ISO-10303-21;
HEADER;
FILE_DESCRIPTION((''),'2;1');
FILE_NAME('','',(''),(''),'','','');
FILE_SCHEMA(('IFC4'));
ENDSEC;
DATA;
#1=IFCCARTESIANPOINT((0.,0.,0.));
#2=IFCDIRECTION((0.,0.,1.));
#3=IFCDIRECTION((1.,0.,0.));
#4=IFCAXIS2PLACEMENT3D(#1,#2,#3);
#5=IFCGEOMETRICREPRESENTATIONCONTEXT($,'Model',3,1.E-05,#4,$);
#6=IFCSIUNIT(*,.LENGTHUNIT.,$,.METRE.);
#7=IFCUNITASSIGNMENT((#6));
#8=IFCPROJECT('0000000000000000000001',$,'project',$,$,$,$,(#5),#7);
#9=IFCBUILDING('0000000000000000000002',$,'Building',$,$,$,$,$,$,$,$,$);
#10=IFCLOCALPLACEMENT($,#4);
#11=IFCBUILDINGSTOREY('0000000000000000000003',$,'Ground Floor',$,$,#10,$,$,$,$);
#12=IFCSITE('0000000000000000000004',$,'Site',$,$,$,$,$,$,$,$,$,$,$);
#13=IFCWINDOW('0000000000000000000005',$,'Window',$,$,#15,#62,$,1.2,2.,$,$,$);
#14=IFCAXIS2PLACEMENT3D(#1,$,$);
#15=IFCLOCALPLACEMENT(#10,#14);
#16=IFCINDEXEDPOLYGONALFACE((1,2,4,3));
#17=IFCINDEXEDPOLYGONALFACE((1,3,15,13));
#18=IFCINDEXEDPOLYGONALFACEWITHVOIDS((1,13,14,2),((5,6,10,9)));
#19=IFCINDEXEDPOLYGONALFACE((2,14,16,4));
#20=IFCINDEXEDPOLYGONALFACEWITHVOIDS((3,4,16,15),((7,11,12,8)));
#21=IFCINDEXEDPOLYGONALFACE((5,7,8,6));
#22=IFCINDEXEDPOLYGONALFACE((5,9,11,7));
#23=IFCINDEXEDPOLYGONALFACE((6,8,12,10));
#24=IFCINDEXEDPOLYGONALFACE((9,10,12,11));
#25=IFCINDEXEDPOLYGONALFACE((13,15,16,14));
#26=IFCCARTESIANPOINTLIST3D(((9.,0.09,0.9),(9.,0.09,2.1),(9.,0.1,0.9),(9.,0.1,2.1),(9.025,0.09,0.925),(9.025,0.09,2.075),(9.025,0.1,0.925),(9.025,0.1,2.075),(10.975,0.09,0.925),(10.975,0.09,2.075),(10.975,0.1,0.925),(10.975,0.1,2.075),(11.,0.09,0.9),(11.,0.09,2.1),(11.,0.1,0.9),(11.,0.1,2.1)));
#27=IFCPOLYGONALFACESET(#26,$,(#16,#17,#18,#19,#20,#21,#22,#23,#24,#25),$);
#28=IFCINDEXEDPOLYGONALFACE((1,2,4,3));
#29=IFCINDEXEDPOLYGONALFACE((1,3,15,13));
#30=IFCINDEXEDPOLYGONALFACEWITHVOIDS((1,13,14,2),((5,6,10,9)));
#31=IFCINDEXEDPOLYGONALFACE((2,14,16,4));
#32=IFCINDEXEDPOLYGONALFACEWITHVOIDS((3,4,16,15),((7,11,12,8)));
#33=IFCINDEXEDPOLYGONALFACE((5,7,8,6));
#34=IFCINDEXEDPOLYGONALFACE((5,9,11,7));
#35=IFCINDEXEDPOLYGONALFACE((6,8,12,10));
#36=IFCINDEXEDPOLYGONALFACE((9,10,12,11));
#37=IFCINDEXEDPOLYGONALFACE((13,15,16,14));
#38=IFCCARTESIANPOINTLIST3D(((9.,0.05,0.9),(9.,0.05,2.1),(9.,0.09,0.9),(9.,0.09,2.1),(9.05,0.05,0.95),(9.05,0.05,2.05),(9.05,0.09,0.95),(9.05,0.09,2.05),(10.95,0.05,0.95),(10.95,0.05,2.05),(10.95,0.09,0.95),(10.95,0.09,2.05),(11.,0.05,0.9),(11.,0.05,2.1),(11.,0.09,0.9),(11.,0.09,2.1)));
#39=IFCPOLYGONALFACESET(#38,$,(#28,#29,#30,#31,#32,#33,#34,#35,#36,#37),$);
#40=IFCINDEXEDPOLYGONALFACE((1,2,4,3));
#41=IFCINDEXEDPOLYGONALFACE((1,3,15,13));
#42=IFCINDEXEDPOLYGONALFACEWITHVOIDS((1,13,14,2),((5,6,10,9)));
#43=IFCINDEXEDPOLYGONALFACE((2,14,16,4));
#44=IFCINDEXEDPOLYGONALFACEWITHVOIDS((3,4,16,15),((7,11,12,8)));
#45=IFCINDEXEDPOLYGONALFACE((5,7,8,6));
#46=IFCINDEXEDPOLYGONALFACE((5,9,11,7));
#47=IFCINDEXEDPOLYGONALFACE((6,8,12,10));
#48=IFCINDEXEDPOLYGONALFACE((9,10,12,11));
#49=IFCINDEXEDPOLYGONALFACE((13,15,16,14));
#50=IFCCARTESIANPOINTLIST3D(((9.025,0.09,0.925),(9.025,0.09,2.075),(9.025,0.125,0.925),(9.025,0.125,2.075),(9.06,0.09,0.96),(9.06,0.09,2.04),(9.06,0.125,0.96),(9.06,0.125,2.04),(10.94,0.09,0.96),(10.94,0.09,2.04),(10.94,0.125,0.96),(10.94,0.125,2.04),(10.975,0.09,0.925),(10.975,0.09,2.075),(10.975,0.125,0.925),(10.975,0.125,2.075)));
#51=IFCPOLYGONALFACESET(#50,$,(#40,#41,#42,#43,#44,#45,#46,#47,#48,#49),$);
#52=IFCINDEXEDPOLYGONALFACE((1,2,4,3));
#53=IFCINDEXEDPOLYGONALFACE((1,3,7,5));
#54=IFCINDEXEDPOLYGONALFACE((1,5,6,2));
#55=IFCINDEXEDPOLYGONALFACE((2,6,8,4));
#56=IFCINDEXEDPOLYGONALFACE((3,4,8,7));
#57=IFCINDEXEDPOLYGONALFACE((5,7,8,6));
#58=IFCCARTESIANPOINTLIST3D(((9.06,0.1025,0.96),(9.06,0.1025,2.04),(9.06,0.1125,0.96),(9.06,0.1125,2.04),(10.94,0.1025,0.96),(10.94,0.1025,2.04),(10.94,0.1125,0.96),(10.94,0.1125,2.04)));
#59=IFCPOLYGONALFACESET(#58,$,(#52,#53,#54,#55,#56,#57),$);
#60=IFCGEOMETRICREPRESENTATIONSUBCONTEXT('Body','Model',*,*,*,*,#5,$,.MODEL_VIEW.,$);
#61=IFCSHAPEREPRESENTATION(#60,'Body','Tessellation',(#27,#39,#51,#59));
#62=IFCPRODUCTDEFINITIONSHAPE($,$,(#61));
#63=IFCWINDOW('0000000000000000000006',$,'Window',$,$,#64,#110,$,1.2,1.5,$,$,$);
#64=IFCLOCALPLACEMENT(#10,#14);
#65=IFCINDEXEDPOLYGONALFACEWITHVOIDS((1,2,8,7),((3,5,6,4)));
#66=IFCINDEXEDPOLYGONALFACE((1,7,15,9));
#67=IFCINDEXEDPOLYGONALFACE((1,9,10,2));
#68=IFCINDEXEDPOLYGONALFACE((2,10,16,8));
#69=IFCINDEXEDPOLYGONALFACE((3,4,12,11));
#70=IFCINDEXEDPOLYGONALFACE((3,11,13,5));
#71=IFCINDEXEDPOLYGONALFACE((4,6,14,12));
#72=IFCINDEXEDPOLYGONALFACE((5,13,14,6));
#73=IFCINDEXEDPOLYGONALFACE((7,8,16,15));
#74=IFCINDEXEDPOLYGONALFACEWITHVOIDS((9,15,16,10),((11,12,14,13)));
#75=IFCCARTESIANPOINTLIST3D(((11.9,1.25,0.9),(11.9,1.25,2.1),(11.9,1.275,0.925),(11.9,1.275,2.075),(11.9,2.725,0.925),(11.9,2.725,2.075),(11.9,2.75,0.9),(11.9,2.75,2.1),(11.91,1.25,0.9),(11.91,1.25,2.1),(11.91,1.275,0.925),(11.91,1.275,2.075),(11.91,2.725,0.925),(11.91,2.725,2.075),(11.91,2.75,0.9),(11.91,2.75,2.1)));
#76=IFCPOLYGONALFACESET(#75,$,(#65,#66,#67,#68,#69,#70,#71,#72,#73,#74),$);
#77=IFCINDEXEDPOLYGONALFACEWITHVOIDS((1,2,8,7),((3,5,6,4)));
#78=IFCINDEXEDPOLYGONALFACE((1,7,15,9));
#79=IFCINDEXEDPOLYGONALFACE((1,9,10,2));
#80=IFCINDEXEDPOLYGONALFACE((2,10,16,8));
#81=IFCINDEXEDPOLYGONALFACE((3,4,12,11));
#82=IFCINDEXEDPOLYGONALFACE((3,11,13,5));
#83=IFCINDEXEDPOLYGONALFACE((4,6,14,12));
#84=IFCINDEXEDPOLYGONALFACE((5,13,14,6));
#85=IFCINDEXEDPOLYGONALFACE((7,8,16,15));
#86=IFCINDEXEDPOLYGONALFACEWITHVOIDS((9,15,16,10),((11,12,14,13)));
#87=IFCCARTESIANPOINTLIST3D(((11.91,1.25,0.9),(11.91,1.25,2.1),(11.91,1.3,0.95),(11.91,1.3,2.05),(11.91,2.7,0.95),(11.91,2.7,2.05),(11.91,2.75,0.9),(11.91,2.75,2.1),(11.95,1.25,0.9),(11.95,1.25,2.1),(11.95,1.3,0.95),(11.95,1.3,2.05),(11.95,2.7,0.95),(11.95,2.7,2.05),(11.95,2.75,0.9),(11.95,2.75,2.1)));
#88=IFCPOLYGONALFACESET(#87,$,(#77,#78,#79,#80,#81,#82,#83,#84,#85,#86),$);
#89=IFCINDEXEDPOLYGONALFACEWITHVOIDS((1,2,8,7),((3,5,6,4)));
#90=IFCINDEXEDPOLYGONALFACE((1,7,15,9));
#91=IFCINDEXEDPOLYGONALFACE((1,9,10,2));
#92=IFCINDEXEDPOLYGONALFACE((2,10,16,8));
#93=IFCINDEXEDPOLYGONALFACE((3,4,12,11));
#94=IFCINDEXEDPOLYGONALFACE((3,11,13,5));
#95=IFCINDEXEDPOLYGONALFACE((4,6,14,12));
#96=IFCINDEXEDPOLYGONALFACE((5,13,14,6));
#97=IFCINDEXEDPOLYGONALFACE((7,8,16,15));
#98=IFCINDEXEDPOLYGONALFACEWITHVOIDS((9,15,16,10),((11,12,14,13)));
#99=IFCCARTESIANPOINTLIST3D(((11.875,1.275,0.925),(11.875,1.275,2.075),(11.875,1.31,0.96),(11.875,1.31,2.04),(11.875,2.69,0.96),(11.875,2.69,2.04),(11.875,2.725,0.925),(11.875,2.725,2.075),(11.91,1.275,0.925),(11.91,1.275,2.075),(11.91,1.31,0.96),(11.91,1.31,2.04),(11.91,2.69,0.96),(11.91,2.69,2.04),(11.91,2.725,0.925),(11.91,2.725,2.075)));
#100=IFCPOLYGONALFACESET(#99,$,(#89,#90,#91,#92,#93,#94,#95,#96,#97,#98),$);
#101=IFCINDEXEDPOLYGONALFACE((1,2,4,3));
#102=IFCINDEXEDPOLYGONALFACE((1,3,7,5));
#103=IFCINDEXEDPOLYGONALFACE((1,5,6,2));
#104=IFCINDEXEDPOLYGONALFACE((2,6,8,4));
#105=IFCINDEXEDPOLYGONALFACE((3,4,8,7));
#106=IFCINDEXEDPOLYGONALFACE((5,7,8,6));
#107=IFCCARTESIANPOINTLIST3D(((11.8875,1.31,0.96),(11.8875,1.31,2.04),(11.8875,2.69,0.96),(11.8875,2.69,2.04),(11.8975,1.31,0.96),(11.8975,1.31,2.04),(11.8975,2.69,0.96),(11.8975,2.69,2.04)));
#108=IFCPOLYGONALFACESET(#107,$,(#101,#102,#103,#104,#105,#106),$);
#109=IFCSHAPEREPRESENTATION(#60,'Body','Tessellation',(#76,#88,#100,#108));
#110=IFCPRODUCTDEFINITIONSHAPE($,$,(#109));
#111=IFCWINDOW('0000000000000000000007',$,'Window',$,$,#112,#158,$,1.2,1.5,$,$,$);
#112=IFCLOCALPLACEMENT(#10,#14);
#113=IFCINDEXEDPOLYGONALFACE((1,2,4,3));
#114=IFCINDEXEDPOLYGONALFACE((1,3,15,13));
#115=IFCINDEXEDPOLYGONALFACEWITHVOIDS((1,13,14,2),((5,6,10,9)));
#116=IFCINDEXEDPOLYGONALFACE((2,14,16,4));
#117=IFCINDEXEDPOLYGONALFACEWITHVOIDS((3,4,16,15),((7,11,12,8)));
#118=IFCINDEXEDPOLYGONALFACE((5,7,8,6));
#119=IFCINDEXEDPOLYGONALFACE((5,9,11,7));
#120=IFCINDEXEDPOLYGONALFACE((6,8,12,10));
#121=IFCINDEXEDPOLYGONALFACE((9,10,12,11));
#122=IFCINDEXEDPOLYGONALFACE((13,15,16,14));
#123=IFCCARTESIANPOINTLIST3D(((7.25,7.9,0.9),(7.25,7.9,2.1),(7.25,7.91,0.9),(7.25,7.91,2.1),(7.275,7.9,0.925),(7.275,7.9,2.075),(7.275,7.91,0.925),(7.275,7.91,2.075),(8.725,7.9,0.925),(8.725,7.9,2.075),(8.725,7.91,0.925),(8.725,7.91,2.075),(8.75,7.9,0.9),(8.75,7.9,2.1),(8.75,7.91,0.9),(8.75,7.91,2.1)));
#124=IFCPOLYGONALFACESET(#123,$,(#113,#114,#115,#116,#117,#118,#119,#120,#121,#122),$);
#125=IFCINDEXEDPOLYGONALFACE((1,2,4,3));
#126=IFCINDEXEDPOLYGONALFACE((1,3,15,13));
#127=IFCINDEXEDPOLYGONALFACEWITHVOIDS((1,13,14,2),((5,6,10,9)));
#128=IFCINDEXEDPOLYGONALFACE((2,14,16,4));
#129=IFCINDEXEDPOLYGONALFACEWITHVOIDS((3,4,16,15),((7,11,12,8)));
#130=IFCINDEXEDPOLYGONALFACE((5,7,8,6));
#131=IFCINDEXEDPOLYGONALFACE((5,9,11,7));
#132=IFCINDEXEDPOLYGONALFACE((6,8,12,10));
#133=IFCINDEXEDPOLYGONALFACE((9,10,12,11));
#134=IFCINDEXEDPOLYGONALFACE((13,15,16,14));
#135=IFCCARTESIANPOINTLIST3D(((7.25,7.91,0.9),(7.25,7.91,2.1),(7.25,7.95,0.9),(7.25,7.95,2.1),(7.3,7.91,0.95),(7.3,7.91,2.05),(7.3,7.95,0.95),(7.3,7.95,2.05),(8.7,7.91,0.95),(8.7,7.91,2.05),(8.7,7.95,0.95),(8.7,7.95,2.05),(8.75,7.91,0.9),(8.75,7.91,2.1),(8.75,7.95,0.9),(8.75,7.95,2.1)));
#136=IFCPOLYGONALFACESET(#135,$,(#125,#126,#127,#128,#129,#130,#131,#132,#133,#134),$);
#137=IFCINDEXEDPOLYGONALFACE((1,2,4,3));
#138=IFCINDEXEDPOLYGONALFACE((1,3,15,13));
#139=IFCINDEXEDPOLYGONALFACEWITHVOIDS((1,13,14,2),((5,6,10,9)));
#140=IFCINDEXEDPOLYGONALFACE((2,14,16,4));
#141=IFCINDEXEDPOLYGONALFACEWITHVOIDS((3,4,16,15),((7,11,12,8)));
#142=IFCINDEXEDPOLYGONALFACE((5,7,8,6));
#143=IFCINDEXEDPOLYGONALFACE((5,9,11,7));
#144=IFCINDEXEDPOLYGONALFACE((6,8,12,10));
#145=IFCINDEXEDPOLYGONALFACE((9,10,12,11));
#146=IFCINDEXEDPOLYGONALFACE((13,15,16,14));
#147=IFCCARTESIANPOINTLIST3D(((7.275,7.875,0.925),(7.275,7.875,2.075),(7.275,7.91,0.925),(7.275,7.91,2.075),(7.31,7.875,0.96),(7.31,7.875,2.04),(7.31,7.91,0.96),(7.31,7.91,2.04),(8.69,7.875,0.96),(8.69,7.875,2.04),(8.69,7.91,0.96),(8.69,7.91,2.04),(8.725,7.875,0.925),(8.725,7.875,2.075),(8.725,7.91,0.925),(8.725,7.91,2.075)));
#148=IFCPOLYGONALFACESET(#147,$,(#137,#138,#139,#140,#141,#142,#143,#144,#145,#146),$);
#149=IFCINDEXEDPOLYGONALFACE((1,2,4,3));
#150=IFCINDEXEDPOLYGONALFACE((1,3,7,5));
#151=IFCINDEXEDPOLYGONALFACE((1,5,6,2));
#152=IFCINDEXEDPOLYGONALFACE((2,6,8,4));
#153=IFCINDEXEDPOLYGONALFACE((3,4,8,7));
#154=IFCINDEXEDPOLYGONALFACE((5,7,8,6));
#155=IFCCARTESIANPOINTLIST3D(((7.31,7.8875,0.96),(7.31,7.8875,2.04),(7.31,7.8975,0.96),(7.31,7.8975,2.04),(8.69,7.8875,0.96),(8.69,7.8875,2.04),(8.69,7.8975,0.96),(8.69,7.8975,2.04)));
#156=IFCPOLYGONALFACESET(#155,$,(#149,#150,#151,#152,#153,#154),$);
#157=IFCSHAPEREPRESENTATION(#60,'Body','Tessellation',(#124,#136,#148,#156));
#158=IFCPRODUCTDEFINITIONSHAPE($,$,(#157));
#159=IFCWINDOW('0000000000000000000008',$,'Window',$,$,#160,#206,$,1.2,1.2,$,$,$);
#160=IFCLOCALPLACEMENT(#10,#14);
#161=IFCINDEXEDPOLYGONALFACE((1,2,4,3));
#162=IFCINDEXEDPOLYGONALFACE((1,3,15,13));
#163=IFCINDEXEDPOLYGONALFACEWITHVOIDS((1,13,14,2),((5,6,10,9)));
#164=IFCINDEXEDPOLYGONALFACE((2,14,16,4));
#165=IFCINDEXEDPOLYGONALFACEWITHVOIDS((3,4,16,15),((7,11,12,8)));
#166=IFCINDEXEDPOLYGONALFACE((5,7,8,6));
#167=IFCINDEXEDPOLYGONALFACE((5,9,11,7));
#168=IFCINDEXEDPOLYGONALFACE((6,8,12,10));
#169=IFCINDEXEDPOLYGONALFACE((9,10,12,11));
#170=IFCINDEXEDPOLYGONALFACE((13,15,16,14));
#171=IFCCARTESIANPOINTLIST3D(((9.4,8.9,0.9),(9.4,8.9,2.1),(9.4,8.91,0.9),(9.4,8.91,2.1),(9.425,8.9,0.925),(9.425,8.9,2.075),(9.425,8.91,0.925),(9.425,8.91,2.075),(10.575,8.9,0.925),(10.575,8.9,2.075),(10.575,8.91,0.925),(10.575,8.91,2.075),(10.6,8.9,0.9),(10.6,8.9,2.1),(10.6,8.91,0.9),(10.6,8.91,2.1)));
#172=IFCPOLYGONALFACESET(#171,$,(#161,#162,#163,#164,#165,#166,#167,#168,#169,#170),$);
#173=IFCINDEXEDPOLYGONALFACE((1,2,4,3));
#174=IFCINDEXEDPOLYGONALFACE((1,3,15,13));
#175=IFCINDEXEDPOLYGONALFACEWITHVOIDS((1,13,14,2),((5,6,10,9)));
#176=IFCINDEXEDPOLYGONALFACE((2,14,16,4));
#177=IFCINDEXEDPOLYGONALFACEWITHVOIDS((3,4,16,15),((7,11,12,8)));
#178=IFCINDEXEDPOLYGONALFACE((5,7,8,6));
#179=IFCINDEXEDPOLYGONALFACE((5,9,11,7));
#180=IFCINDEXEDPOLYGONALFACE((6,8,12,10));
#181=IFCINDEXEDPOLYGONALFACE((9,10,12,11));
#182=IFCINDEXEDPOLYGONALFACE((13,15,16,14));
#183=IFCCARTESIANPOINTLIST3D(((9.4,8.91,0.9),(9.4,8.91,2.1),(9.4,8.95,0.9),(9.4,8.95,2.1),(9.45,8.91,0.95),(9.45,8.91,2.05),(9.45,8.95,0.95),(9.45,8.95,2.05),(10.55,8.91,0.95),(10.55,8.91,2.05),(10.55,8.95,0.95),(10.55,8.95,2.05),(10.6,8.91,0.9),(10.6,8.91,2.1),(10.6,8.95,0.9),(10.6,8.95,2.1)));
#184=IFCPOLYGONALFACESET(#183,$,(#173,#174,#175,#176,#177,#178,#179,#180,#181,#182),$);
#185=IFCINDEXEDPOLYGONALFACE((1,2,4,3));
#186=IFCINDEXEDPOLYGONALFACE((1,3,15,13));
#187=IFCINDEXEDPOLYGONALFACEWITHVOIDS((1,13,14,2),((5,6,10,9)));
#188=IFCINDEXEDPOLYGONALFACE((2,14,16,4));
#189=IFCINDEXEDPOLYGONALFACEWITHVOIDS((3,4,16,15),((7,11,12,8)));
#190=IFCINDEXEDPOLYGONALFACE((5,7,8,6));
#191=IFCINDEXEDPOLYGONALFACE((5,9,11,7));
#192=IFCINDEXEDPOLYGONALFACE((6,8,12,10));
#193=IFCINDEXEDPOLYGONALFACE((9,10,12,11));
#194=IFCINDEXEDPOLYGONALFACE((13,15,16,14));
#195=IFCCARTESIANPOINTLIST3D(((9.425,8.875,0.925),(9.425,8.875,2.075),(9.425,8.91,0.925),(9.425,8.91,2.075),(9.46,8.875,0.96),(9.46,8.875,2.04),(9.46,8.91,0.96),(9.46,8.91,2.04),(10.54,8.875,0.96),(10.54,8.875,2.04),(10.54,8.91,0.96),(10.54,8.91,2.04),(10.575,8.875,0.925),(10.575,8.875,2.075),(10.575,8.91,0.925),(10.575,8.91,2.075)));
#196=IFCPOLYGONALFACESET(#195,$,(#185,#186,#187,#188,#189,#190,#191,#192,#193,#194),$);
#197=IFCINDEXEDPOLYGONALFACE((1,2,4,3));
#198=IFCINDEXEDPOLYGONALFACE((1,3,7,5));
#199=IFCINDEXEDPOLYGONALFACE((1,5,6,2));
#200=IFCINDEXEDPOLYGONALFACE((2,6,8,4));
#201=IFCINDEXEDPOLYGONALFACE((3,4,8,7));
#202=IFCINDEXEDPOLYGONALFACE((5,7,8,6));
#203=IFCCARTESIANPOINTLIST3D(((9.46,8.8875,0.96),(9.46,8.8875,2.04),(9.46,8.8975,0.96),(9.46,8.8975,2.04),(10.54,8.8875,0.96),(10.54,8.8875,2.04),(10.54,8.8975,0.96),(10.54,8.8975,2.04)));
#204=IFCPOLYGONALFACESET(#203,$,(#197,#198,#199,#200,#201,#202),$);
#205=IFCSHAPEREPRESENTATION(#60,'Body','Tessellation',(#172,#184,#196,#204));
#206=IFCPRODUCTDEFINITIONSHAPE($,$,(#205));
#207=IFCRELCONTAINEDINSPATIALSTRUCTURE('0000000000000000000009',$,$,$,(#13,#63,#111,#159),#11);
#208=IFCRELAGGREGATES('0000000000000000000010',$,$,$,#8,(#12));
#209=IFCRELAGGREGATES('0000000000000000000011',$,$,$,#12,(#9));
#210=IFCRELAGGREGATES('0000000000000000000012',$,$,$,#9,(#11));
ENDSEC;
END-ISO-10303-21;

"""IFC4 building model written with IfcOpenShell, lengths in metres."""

from ifc_helpers import new_model, si_unit, frame, origin_with_axes, place, context, subcontext, project, spatial, line, indexed_curve, outline, extrude, element, save


model = new_model("IFC4")

# Units and contexts
model_context = context("Model", 3, precision=1e-05, world=origin_with_axes())
body_context = subcontext(model_context, "Body", "Model", "MODEL_VIEW")
ifc_project = project(units=[si_unit("LENGTHUNIT", "METRE")], contexts=[model_context])

# Site, building, storey
site = spatial("IfcSite", under=ifc_project, Name="Site")
building = spatial("IfcBuilding", under=site, Name="Building")
storey_placement = place(None, origin_with_axes())
storey = spatial("IfcBuildingStorey", under=building, at=storey_placement, Name="Ground Floor")

# Windows
window_placement = place(storey_placement, frame((9.0, 0.0, 0.9), z_axis=(0.0, 0.0, 1.0), x_axis=(1.0, 0.0, 0.0)))
element("IfcWindow", 1, at=window_placement, inside=storey, Name="Window", OverallHeight=1.2, OverallWidth=2.0, context=body_context, shape_type="SweptSolid", body=[
    extrude(outline(indexed_curve([(0.0, 0.0), (2.0, 0.0), (2.0, 1.2), (0.0, 1.2)], segments=[line(1, 2, 3, 4, 1)]), holes=[indexed_curve([(0.025, 0.025), (1.975, 0.025), (1.975, 1.175), (0.025, 1.175)], segments=[line(1, 2, 3, 4, 1)])]), frame((0.0, 0.09, 0.0), z_axis=(0.0, -1.0, 0.0), x_axis=(1.0, 0.0, 0.0)), (0.0, 0.0, -1.0), 0.01),
    extrude(outline(indexed_curve([(0.0, 0.0), (2.0, 0.0), (2.0, 1.2), (0.0, 1.2)], segments=[line(1, 2, 3, 4, 1)]), holes=[indexed_curve([(0.05, 0.05), (1.95, 0.05), (1.95, 1.15), (0.05, 1.15)], segments=[line(1, 2, 3, 4, 1)])]), frame((0.0, 0.05, 0.0), z_axis=(0.0, -1.0, 0.0), x_axis=(1.0, 0.0, 0.0)), (0.0, 0.0, -1.0), 0.04),
    extrude(outline(indexed_curve([(0.0, 0.0), (1.95, 0.0), (1.95, 1.15), (0.0, 1.15)], segments=[line(1, 2, 3, 4, 1)]), holes=[indexed_curve([(0.035, 0.035), (1.915, 0.035), (1.915, 1.115), (0.035, 1.115)], segments=[line(1, 2, 3, 4, 1)])]), frame((0.025, 0.09, 0.025), z_axis=(0.0, -1.0, 0.0), x_axis=(1.0, 0.0, 0.0)), (0.0, 0.0, -1.0), 0.035),
    extrude(outline(indexed_curve([(0.035, 0.035), (1.915, 0.035), (1.915, 1.115), (0.035, 1.115)], segments=[line(1, 2, 3, 4, 1)])), frame((0.025, 0.1025, 0.025), z_axis=(0.0, -1.0, 0.0), x_axis=(1.0, 0.0, 0.0)), (0.0, 0.0, -1.0), 0.01),
])
for number, where, z_axis, x_axis, name in (
    (2, (12.0, 1.25, 0.9), (0.0, 0.0, 1.0), (0.0, 1.0, 0.0), "Window"),
    (3, (8.75, 8.0, 0.9), (0.0, 0.0, 1.0), (-1.0, 0.0, 0.0), "Window"),
):
    element("IfcWindow", number, at=place(storey_placement, frame(where, z_axis=z_axis, x_axis=x_axis)), inside=storey, Name=name, OverallHeight=1.2, OverallWidth=1.5, context=body_context, shape_type="SweptSolid", body=[
        extrude(outline(indexed_curve([(0.0, 0.0), (1.5, 0.0), (1.5, 1.2), (0.0, 1.2)], segments=[line(1, 2, 3, 4, 1)]), holes=[indexed_curve([(0.025, 0.025), (1.475, 0.025), (1.475, 1.175), (0.025, 1.175)], segments=[line(1, 2, 3, 4, 1)])]), frame((0.0, 0.09, 0.0), z_axis=(0.0, -1.0, 0.0), x_axis=(1.0, 0.0, 0.0)), (0.0, 0.0, -1.0), 0.01),
        extrude(outline(indexed_curve([(0.0, 0.0), (1.5, 0.0), (1.5, 1.2), (0.0, 1.2)], segments=[line(1, 2, 3, 4, 1)]), holes=[indexed_curve([(0.05, 0.05), (1.45, 0.05), (1.45, 1.15), (0.05, 1.15)], segments=[line(1, 2, 3, 4, 1)])]), frame((0.0, 0.05, 0.0), z_axis=(0.0, -1.0, 0.0), x_axis=(1.0, 0.0, 0.0)), (0.0, 0.0, -1.0), 0.04),
        extrude(outline(indexed_curve([(0.0, 0.0), (1.45, 0.0), (1.45, 1.15), (0.0, 1.15)], segments=[line(1, 2, 3, 4, 1)]), holes=[indexed_curve([(0.035, 0.035), (1.415, 0.035), (1.415, 1.115), (0.035, 1.115)], segments=[line(1, 2, 3, 4, 1)])]), frame((0.025, 0.09, 0.025), z_axis=(0.0, -1.0, 0.0), x_axis=(1.0, 0.0, 0.0)), (0.0, 0.0, -1.0), 0.035),
        extrude(outline(indexed_curve([(0.035, 0.035), (1.415, 0.035), (1.415, 1.115), (0.035, 1.115)], segments=[line(1, 2, 3, 4, 1)])), frame((0.025, 0.1025, 0.025), z_axis=(0.0, -1.0, 0.0), x_axis=(1.0, 0.0, 0.0)), (0.0, 0.0, -1.0), 0.01),
    ])
for number, where, z_axis, x_axis, name in (
    (4, (10.6, 9.0, 0.9), (0.0, 0.0, 1.0), (-1.0, 0.0, 0.0), "Window"),
):
    element("IfcWindow", number, at=place(storey_placement, frame(where, z_axis=z_axis, x_axis=x_axis)), inside=storey, Name=name, OverallHeight=1.2, OverallWidth=1.2, context=body_context, shape_type="SweptSolid", body=[
        extrude(outline(indexed_curve([(0.0, 0.0), (1.2, 0.0), (1.2, 1.2), (0.0, 1.2)], segments=[line(1, 2, 3, 4, 1)]), holes=[indexed_curve([(0.025, 0.025), (1.175, 0.025), (1.175, 1.175), (0.025, 1.175)], segments=[line(1, 2, 3, 4, 1)])]), frame((0.0, 0.09, 0.0), z_axis=(0.0, -1.0, 0.0), x_axis=(1.0, 0.0, 0.0)), (0.0, 0.0, -1.0), 0.01),
        extrude(outline(indexed_curve([(0.0, 0.0), (1.2, 0.0), (1.2, 1.2), (0.0, 1.2)], segments=[line(1, 2, 3, 4, 1)]), holes=[indexed_curve([(0.05, 0.05), (1.15, 0.05), (1.15, 1.15), (0.05, 1.15)], segments=[line(1, 2, 3, 4, 1)])]), frame((0.0, 0.05, 0.0), z_axis=(0.0, -1.0, 0.0), x_axis=(1.0, 0.0, 0.0)), (0.0, 0.0, -1.0), 0.04),
        extrude(outline(indexed_curve([(0.0, 0.0), (1.15, 0.0), (1.15, 1.15), (0.0, 1.15)], segments=[line(1, 2, 3, 4, 1)]), holes=[indexed_curve([(0.035, 0.035), (1.115, 0.035), (1.115, 1.115), (0.035, 1.115)], segments=[line(1, 2, 3, 4, 1)])]), frame((0.025, 0.09, 0.025), z_axis=(0.0, -1.0, 0.0), x_axis=(1.0, 0.0, 0.0)), (0.0, 0.0, -1.0), 0.035),
        extrude(outline(indexed_curve([(0.035, 0.035), (1.115, 0.035), (1.115, 1.115), (0.035, 1.115)], segments=[line(1, 2, 3, 4, 1)])), frame((0.025, 0.1025, 0.025), z_axis=(0.0, -1.0, 0.0), x_axis=(1.0, 0.0, 0.0)), (0.0, 0.0, -1.0), 0.01),
    ])

save(model, "model.ifc")
